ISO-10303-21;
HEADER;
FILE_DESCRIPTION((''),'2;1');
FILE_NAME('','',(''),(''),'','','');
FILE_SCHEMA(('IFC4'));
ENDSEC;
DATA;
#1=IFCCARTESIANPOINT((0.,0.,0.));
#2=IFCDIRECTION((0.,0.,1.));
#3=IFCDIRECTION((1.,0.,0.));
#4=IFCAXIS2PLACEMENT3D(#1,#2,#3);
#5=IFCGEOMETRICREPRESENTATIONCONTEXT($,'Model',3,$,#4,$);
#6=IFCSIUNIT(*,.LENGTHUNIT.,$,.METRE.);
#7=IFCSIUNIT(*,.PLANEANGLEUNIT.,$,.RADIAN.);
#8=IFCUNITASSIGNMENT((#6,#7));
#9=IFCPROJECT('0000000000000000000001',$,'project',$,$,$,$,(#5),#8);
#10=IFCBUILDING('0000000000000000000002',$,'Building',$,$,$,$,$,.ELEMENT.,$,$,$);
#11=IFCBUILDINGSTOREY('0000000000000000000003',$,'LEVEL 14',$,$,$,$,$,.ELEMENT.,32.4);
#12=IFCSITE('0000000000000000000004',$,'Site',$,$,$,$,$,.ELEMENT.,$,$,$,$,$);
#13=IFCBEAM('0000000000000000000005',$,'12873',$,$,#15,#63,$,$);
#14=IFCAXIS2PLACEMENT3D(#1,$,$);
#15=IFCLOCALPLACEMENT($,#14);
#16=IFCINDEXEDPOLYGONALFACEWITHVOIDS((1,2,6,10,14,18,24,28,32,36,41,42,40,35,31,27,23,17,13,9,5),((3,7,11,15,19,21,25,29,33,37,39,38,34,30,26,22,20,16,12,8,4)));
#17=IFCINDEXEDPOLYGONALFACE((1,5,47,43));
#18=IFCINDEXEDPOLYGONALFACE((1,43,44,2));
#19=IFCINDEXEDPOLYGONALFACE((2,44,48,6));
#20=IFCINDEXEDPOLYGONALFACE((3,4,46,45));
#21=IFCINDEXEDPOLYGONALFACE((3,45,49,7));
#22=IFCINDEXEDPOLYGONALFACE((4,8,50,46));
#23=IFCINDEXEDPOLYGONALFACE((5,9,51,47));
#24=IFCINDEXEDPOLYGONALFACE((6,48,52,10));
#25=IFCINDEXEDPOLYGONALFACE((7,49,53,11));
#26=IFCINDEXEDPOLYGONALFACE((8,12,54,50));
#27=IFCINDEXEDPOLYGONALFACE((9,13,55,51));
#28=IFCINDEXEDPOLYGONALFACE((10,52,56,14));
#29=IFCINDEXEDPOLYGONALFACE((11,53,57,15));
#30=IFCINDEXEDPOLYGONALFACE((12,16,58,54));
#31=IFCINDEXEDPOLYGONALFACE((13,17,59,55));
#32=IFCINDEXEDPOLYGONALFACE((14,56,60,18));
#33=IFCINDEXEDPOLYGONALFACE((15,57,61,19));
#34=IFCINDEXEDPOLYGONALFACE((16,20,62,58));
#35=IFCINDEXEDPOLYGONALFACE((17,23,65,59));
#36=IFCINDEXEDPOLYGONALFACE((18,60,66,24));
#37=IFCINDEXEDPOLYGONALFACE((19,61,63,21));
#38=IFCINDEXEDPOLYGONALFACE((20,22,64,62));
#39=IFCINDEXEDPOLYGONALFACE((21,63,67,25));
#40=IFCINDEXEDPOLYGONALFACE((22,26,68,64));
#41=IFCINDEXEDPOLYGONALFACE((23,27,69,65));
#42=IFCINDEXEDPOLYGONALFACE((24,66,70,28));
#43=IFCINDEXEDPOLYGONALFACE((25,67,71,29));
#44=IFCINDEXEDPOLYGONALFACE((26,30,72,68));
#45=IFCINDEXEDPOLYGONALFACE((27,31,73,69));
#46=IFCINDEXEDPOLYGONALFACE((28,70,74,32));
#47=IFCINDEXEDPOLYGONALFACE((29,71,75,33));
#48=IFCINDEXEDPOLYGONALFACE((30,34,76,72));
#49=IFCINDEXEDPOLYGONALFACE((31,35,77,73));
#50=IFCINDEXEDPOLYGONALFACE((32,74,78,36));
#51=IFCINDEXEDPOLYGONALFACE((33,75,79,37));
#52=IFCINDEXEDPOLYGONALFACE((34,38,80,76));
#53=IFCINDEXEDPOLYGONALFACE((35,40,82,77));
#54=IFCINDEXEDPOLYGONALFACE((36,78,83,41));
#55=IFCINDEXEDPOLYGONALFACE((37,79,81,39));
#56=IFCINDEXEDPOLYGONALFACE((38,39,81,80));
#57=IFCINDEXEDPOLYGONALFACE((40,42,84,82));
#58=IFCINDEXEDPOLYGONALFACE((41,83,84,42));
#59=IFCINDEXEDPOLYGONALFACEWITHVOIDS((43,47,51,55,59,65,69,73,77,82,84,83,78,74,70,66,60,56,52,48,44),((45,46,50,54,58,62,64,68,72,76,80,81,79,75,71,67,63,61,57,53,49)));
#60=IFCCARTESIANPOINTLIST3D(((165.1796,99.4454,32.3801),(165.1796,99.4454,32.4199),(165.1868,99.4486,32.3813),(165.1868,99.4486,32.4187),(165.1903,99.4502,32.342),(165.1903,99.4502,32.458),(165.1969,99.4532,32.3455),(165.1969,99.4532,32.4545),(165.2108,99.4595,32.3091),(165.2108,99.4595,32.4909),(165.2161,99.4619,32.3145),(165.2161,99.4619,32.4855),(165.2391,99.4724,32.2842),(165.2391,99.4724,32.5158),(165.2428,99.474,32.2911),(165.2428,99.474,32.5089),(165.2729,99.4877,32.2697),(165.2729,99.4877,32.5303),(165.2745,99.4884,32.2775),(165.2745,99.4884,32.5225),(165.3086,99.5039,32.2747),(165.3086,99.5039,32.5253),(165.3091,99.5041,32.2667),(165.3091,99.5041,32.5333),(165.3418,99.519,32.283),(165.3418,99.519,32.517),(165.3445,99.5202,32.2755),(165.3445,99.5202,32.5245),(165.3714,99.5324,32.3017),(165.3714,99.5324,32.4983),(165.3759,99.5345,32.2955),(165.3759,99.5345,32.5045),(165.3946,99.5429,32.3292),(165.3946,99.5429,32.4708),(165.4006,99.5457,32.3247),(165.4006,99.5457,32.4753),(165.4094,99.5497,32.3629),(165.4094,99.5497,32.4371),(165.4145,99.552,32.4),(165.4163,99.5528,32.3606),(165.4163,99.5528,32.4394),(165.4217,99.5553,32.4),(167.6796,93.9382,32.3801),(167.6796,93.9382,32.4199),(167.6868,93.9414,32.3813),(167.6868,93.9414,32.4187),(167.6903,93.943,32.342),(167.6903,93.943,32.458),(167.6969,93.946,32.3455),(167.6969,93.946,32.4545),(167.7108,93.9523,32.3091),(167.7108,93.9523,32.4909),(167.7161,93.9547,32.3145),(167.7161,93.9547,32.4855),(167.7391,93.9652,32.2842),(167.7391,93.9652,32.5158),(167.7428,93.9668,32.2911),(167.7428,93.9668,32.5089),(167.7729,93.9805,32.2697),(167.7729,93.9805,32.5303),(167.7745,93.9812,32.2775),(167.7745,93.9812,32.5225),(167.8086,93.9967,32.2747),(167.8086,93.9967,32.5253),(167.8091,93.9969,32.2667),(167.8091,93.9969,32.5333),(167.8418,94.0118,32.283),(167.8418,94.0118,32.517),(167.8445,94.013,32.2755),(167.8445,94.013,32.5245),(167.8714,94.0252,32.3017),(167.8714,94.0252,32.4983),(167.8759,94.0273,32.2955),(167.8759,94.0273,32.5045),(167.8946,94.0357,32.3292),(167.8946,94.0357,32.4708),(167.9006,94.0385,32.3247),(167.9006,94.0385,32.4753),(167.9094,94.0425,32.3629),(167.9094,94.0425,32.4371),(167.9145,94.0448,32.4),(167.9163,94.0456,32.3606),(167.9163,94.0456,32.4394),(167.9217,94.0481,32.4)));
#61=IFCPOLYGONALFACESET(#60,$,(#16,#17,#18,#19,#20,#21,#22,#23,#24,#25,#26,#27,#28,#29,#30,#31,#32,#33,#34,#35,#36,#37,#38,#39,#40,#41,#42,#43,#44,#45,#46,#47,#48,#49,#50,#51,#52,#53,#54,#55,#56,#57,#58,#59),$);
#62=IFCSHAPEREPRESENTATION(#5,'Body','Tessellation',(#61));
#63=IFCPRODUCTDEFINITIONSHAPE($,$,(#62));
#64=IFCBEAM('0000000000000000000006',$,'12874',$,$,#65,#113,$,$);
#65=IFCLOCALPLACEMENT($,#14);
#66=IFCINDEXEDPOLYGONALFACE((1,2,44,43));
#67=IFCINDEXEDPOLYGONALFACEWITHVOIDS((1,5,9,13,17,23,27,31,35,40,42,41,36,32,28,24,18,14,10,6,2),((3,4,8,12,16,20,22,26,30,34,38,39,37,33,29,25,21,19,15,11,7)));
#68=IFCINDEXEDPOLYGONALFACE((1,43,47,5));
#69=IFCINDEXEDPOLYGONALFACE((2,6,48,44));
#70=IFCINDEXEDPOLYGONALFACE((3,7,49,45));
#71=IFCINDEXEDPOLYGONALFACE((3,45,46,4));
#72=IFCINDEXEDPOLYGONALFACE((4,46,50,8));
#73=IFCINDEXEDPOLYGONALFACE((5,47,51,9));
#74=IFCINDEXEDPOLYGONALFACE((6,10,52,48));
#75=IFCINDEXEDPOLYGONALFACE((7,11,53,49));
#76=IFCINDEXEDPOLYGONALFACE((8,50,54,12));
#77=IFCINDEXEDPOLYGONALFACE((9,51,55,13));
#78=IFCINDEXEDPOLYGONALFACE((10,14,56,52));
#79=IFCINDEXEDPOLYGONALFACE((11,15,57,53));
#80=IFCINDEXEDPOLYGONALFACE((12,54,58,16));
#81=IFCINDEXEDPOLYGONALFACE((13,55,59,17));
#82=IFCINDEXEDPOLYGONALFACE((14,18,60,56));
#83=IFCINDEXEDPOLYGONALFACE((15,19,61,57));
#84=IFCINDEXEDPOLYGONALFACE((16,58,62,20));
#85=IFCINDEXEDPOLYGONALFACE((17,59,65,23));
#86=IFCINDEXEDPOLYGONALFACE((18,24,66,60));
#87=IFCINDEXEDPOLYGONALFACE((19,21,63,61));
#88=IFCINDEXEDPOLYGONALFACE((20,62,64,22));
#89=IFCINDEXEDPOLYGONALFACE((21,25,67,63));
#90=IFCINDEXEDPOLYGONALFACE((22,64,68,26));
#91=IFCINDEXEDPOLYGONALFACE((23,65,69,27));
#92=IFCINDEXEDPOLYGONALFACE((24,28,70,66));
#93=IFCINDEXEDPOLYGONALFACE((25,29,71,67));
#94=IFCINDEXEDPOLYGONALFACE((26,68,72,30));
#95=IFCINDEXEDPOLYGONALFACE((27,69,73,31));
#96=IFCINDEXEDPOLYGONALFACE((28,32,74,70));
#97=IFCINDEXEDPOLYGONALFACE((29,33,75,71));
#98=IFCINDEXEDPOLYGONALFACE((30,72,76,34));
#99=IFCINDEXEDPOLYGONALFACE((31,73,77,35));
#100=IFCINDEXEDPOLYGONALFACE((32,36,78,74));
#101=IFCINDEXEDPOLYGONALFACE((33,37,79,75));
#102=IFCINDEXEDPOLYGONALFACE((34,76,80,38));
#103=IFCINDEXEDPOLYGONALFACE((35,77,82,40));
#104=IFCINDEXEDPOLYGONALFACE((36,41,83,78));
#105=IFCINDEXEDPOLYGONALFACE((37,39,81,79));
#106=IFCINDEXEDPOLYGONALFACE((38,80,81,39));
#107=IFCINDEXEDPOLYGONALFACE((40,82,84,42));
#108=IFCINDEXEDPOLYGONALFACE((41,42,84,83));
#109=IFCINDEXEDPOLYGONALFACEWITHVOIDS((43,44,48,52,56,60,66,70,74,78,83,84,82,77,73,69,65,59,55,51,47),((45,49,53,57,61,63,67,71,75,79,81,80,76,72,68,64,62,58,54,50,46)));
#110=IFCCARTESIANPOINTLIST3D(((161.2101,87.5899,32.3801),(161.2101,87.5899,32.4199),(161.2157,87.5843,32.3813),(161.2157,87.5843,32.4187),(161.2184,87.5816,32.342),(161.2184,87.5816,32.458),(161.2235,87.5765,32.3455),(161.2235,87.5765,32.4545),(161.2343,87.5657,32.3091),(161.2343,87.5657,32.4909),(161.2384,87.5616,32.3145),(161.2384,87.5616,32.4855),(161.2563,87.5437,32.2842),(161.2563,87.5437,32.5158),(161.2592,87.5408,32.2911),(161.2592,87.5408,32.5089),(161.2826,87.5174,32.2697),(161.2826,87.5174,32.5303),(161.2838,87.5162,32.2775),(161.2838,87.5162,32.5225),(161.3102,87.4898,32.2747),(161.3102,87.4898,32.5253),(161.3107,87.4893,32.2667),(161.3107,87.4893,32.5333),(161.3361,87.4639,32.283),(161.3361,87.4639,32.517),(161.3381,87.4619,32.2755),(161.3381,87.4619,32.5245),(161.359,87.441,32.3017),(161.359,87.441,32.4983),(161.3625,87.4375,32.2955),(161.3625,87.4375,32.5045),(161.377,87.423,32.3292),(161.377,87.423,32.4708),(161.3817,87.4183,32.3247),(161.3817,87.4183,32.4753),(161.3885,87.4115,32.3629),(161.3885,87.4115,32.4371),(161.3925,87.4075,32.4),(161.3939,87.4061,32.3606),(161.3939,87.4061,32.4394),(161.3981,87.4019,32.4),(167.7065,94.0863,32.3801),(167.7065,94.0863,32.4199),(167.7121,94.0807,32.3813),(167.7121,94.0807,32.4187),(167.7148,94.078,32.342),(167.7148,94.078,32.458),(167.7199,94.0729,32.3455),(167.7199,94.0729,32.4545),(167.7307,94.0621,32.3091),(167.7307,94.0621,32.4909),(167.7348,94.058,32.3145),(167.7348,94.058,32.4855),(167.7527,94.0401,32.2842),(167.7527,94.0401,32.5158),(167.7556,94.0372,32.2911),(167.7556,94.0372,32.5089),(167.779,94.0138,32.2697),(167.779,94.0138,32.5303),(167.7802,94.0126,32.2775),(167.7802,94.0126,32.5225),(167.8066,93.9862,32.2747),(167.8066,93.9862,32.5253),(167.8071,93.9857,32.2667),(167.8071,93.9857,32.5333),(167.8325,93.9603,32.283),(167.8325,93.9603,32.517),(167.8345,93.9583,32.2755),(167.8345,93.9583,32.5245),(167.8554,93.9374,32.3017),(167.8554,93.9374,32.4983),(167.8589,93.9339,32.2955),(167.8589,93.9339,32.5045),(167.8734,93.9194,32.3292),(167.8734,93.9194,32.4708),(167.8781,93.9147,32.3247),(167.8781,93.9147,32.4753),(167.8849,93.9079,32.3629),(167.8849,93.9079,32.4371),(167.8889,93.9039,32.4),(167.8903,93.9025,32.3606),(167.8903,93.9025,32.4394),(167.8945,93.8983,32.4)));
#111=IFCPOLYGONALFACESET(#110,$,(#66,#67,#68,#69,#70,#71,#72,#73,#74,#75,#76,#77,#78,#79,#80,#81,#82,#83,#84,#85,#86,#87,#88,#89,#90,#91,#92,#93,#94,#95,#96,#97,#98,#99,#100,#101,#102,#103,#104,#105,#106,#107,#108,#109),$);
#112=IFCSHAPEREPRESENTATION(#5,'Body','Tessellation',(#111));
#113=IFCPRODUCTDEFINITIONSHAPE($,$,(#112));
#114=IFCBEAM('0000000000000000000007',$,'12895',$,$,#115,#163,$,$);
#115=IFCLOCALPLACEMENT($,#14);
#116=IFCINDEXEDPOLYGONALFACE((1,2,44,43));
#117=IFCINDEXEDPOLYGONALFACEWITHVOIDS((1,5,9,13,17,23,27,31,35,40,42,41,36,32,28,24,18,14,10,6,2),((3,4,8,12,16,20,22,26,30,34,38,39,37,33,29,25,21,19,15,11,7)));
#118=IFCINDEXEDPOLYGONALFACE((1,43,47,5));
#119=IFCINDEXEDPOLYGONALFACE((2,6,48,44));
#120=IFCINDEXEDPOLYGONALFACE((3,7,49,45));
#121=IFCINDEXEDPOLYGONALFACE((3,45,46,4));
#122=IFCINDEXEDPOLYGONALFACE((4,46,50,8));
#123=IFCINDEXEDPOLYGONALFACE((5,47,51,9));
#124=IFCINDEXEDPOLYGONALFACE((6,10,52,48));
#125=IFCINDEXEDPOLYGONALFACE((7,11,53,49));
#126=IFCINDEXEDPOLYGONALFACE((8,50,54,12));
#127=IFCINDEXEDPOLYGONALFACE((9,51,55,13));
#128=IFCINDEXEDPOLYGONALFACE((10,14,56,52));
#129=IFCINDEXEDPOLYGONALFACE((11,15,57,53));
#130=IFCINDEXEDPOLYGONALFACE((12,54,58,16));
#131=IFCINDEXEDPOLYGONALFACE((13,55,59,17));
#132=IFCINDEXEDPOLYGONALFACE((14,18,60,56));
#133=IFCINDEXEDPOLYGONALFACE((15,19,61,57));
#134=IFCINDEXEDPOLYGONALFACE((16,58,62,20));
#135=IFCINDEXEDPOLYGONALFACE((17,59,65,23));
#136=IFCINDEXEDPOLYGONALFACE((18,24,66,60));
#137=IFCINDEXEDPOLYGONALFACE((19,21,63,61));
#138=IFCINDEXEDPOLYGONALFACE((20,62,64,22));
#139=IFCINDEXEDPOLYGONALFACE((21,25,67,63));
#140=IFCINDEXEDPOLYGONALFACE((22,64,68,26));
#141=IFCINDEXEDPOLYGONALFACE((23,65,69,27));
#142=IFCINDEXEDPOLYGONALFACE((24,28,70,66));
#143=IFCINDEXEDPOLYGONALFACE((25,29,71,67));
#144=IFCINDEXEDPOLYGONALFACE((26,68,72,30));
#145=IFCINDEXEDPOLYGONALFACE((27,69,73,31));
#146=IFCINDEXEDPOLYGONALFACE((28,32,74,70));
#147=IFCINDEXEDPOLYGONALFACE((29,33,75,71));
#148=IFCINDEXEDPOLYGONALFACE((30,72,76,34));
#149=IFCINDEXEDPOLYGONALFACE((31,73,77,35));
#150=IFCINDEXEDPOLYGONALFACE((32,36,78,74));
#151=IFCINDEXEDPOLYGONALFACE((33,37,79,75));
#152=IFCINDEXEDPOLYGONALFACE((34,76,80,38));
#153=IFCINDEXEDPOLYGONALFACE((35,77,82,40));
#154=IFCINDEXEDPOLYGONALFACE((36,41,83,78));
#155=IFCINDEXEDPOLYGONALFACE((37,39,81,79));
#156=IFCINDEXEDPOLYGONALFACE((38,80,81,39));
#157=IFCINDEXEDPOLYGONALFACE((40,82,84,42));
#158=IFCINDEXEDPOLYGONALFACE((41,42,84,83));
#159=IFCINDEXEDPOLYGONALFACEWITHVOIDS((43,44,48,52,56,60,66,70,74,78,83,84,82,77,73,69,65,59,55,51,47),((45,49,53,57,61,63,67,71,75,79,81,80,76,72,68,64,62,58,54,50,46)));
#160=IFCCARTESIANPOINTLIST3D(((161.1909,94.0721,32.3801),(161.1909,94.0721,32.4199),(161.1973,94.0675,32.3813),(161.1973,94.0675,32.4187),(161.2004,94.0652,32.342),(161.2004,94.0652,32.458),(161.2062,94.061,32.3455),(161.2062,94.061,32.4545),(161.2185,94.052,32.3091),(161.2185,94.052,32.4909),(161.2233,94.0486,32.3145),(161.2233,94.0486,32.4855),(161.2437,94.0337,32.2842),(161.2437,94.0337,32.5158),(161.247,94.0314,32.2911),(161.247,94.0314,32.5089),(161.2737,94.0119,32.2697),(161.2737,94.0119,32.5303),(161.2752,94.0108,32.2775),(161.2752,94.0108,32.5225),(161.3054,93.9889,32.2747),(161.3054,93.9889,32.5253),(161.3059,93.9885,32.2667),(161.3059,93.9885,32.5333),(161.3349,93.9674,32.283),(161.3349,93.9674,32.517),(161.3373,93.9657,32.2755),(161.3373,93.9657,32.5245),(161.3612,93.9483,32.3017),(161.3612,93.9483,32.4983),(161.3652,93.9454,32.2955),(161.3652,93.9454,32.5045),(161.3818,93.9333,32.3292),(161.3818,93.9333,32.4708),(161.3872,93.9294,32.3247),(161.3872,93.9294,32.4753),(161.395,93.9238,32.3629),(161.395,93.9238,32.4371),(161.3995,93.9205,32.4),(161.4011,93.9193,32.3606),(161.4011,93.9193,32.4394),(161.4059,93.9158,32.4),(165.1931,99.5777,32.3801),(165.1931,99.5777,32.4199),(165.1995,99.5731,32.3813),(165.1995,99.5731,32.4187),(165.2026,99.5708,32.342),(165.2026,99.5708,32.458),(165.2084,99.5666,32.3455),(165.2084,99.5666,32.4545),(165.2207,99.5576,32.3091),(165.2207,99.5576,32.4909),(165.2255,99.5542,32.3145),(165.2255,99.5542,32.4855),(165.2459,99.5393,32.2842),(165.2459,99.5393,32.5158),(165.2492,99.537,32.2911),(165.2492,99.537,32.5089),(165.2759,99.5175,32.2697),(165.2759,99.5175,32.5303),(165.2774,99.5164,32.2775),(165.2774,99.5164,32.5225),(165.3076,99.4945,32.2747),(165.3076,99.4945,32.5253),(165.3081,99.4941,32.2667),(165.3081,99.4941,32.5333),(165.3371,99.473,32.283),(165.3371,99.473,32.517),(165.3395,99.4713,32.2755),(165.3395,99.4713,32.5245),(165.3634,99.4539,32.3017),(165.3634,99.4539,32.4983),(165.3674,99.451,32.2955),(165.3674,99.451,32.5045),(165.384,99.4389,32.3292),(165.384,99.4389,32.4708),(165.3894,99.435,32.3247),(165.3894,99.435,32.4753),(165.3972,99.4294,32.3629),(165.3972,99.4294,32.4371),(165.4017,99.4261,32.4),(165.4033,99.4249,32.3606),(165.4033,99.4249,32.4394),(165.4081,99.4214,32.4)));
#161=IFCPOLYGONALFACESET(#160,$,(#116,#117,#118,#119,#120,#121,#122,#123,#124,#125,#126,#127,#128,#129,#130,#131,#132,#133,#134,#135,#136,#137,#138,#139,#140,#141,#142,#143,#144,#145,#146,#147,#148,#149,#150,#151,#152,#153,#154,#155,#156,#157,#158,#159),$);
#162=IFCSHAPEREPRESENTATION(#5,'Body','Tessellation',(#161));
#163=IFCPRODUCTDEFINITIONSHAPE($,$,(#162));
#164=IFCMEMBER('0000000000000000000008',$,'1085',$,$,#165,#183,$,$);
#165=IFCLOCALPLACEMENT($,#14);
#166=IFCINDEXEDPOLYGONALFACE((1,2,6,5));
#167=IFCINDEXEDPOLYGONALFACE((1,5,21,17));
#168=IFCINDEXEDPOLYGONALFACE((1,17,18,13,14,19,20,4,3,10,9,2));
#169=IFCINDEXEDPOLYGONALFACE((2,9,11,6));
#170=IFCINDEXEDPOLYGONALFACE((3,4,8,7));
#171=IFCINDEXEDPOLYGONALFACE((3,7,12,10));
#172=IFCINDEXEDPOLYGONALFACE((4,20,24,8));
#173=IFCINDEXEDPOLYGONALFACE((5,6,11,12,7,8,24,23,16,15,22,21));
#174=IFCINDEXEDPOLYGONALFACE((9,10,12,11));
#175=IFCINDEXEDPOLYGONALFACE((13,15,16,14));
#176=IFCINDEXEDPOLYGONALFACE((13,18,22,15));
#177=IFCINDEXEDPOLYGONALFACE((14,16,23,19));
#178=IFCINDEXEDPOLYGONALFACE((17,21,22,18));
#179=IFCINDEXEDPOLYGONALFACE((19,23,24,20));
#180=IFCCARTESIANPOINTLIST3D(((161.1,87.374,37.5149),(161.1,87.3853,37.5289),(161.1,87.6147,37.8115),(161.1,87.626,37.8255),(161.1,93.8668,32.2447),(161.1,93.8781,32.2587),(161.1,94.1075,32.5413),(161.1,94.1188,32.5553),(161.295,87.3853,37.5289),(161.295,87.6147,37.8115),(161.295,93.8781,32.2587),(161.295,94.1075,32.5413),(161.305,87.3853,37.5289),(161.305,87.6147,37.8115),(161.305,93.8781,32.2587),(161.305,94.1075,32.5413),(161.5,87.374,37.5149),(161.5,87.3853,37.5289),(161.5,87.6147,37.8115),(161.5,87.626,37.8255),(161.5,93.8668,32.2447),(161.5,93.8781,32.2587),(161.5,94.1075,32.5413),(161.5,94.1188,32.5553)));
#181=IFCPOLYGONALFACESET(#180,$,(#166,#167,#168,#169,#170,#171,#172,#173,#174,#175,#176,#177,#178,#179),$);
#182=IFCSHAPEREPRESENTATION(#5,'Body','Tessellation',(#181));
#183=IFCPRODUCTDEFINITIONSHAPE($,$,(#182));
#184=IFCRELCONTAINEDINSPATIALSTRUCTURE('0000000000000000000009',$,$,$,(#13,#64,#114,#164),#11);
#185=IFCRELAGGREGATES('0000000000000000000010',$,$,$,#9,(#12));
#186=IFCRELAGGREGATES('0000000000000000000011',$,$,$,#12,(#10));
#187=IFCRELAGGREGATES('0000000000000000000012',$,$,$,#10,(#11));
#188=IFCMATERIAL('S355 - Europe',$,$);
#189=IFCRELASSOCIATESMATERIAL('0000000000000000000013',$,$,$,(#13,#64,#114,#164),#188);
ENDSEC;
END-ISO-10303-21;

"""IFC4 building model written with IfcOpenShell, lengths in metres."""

from ifc_helpers import new_model, si_unit, frame, origin_with_axes, origin_2d_with_axis, place, context, project, spatial, hollow_circle, i_section, extrude, material, material_profile, profile_set, profile_usage, element, save


model = new_model("IFC4")

# Units and contexts
model_context = context("Model", 3, world=origin_with_axes())
ifc_project = project(units=[si_unit("LENGTHUNIT", "METRE"), si_unit("PLANEANGLEUNIT", "RADIAN")], contexts=[model_context])

# Site, building, storey
site = spatial("IfcSite", under=ifc_project, Name="Site", CompositionType="ELEMENT")
building = spatial("IfcBuilding", under=site, Name="Building", CompositionType="ELEMENT")
storey = spatial("IfcBuildingStorey", under=building, Name="LEVEL 14", CompositionType="ELEMENT", Elevation=32.4)

# Shared definitions
ifc_material = material(Name="S355 - Europe")

# Beams
ifc_material_profile_1 = material_profile(ifc_material, hollow_circle(Radius=0.1337, WallThickness=0.008, at=origin_2d_with_axis()))
ifc_profile_set_1 = profile_set([ifc_material_profile_1])
ifc_profile_usage_1 = profile_usage(ifc_profile_set_1, cardinal=10)
beam_1_placement = place(None, frame((165.3, 99.5, 32.4), z_axis=(0.413354, -0.91057, 0.0), x_axis=(0.91057, 0.413354, 0.0)))
element("IfcBeam", 1, at=beam_1_placement, inside=storey, material=ifc_profile_usage_1, Name="12873", context=model_context, shape_type="SweptSolid", body=[
    extrude(hollow_circle(Radius=0.1337, WallThickness=0.008, at=origin_2d_with_axis()), origin_with_axes(), (0.0, 0.0, 1.0), 6.0481),
])
ifc_material_profile_2 = material_profile(ifc_material, hollow_circle(Radius=0.1337, WallThickness=0.008, at=origin_2d_with_axis()))
ifc_profile_set_2 = profile_set([ifc_material_profile_2])
ifc_profile_usage_2 = profile_usage(ifc_profile_set_2, cardinal=10)
beam_2_placement = place(None, frame((167.8, 93.9928, 32.4), z_axis=(-0.707107, -0.707107, 0.0), x_axis=(0.707499, -0.706715, 0.0)))
element("IfcBeam", 2, at=beam_2_placement, inside=storey, material=ifc_profile_usage_2, Name="12874", context=model_context, shape_type="SweptSolid", body=[
    extrude(hollow_circle(Radius=0.1337, WallThickness=0.008, at=origin_2d_with_axis()), origin_with_axes(), (0.0, 0.0, 1.0), 9.1873),
])
ifc_material_profile_3 = material_profile(ifc_material, hollow_circle(Radius=0.1337, WallThickness=0.008, at=origin_2d_with_axis()))
ifc_profile_set_3 = profile_set([ifc_material_profile_3])
ifc_profile_usage_3 = profile_usage(ifc_profile_set_3, cardinal=10)
beam_3_placement = place(None, frame((165.3, 99.5, 32.4), z_axis=(-0.587992, -0.808867, 0.0), x_axis=(0.809096, -0.587676, 0.0)))
element("IfcBeam", 3, at=beam_3_placement, inside=storey, material=ifc_profile_usage_3, Name="12895", context=model_context, shape_type="SweptSolid", body=[
    extrude(hollow_circle(Radius=0.1337, WallThickness=0.008, at=origin_2d_with_axis()), origin_with_axes(), (0.0, 0.0, 1.0), 6.8066),
])

# Member
ifc_material_profile_4 = material_profile(ifc_material, i_section(OverallWidth=0.4, OverallDepth=0.4, WebThickness=0.01, FlangeThickness=0.018, at=origin_2d_with_axis()))
ifc_profile_set_4 = profile_set([ifc_material_profile_4])
ifc_profile_usage_4 = profile_usage(ifc_profile_set_4, cardinal=10)
member_1_placement = place(None, frame((161.3, 93.9928, 32.4), z_axis=(0.0, -0.776418, 0.630218), x_axis=(1.0, 0.0, 0.0)))
element("IfcMember", 4, at=member_1_placement, inside=storey, material=ifc_profile_usage_4, Name="1085", context=model_context, shape_type="SweptSolid", body=[
    extrude(i_section(OverallWidth=0.4, OverallDepth=0.4, WebThickness=0.01, FlangeThickness=0.018, at=origin_2d_with_axis()), origin_with_axes(), (0.0, 0.0, 1.0), 8.3625),
])

save(model, "model.ifc")
